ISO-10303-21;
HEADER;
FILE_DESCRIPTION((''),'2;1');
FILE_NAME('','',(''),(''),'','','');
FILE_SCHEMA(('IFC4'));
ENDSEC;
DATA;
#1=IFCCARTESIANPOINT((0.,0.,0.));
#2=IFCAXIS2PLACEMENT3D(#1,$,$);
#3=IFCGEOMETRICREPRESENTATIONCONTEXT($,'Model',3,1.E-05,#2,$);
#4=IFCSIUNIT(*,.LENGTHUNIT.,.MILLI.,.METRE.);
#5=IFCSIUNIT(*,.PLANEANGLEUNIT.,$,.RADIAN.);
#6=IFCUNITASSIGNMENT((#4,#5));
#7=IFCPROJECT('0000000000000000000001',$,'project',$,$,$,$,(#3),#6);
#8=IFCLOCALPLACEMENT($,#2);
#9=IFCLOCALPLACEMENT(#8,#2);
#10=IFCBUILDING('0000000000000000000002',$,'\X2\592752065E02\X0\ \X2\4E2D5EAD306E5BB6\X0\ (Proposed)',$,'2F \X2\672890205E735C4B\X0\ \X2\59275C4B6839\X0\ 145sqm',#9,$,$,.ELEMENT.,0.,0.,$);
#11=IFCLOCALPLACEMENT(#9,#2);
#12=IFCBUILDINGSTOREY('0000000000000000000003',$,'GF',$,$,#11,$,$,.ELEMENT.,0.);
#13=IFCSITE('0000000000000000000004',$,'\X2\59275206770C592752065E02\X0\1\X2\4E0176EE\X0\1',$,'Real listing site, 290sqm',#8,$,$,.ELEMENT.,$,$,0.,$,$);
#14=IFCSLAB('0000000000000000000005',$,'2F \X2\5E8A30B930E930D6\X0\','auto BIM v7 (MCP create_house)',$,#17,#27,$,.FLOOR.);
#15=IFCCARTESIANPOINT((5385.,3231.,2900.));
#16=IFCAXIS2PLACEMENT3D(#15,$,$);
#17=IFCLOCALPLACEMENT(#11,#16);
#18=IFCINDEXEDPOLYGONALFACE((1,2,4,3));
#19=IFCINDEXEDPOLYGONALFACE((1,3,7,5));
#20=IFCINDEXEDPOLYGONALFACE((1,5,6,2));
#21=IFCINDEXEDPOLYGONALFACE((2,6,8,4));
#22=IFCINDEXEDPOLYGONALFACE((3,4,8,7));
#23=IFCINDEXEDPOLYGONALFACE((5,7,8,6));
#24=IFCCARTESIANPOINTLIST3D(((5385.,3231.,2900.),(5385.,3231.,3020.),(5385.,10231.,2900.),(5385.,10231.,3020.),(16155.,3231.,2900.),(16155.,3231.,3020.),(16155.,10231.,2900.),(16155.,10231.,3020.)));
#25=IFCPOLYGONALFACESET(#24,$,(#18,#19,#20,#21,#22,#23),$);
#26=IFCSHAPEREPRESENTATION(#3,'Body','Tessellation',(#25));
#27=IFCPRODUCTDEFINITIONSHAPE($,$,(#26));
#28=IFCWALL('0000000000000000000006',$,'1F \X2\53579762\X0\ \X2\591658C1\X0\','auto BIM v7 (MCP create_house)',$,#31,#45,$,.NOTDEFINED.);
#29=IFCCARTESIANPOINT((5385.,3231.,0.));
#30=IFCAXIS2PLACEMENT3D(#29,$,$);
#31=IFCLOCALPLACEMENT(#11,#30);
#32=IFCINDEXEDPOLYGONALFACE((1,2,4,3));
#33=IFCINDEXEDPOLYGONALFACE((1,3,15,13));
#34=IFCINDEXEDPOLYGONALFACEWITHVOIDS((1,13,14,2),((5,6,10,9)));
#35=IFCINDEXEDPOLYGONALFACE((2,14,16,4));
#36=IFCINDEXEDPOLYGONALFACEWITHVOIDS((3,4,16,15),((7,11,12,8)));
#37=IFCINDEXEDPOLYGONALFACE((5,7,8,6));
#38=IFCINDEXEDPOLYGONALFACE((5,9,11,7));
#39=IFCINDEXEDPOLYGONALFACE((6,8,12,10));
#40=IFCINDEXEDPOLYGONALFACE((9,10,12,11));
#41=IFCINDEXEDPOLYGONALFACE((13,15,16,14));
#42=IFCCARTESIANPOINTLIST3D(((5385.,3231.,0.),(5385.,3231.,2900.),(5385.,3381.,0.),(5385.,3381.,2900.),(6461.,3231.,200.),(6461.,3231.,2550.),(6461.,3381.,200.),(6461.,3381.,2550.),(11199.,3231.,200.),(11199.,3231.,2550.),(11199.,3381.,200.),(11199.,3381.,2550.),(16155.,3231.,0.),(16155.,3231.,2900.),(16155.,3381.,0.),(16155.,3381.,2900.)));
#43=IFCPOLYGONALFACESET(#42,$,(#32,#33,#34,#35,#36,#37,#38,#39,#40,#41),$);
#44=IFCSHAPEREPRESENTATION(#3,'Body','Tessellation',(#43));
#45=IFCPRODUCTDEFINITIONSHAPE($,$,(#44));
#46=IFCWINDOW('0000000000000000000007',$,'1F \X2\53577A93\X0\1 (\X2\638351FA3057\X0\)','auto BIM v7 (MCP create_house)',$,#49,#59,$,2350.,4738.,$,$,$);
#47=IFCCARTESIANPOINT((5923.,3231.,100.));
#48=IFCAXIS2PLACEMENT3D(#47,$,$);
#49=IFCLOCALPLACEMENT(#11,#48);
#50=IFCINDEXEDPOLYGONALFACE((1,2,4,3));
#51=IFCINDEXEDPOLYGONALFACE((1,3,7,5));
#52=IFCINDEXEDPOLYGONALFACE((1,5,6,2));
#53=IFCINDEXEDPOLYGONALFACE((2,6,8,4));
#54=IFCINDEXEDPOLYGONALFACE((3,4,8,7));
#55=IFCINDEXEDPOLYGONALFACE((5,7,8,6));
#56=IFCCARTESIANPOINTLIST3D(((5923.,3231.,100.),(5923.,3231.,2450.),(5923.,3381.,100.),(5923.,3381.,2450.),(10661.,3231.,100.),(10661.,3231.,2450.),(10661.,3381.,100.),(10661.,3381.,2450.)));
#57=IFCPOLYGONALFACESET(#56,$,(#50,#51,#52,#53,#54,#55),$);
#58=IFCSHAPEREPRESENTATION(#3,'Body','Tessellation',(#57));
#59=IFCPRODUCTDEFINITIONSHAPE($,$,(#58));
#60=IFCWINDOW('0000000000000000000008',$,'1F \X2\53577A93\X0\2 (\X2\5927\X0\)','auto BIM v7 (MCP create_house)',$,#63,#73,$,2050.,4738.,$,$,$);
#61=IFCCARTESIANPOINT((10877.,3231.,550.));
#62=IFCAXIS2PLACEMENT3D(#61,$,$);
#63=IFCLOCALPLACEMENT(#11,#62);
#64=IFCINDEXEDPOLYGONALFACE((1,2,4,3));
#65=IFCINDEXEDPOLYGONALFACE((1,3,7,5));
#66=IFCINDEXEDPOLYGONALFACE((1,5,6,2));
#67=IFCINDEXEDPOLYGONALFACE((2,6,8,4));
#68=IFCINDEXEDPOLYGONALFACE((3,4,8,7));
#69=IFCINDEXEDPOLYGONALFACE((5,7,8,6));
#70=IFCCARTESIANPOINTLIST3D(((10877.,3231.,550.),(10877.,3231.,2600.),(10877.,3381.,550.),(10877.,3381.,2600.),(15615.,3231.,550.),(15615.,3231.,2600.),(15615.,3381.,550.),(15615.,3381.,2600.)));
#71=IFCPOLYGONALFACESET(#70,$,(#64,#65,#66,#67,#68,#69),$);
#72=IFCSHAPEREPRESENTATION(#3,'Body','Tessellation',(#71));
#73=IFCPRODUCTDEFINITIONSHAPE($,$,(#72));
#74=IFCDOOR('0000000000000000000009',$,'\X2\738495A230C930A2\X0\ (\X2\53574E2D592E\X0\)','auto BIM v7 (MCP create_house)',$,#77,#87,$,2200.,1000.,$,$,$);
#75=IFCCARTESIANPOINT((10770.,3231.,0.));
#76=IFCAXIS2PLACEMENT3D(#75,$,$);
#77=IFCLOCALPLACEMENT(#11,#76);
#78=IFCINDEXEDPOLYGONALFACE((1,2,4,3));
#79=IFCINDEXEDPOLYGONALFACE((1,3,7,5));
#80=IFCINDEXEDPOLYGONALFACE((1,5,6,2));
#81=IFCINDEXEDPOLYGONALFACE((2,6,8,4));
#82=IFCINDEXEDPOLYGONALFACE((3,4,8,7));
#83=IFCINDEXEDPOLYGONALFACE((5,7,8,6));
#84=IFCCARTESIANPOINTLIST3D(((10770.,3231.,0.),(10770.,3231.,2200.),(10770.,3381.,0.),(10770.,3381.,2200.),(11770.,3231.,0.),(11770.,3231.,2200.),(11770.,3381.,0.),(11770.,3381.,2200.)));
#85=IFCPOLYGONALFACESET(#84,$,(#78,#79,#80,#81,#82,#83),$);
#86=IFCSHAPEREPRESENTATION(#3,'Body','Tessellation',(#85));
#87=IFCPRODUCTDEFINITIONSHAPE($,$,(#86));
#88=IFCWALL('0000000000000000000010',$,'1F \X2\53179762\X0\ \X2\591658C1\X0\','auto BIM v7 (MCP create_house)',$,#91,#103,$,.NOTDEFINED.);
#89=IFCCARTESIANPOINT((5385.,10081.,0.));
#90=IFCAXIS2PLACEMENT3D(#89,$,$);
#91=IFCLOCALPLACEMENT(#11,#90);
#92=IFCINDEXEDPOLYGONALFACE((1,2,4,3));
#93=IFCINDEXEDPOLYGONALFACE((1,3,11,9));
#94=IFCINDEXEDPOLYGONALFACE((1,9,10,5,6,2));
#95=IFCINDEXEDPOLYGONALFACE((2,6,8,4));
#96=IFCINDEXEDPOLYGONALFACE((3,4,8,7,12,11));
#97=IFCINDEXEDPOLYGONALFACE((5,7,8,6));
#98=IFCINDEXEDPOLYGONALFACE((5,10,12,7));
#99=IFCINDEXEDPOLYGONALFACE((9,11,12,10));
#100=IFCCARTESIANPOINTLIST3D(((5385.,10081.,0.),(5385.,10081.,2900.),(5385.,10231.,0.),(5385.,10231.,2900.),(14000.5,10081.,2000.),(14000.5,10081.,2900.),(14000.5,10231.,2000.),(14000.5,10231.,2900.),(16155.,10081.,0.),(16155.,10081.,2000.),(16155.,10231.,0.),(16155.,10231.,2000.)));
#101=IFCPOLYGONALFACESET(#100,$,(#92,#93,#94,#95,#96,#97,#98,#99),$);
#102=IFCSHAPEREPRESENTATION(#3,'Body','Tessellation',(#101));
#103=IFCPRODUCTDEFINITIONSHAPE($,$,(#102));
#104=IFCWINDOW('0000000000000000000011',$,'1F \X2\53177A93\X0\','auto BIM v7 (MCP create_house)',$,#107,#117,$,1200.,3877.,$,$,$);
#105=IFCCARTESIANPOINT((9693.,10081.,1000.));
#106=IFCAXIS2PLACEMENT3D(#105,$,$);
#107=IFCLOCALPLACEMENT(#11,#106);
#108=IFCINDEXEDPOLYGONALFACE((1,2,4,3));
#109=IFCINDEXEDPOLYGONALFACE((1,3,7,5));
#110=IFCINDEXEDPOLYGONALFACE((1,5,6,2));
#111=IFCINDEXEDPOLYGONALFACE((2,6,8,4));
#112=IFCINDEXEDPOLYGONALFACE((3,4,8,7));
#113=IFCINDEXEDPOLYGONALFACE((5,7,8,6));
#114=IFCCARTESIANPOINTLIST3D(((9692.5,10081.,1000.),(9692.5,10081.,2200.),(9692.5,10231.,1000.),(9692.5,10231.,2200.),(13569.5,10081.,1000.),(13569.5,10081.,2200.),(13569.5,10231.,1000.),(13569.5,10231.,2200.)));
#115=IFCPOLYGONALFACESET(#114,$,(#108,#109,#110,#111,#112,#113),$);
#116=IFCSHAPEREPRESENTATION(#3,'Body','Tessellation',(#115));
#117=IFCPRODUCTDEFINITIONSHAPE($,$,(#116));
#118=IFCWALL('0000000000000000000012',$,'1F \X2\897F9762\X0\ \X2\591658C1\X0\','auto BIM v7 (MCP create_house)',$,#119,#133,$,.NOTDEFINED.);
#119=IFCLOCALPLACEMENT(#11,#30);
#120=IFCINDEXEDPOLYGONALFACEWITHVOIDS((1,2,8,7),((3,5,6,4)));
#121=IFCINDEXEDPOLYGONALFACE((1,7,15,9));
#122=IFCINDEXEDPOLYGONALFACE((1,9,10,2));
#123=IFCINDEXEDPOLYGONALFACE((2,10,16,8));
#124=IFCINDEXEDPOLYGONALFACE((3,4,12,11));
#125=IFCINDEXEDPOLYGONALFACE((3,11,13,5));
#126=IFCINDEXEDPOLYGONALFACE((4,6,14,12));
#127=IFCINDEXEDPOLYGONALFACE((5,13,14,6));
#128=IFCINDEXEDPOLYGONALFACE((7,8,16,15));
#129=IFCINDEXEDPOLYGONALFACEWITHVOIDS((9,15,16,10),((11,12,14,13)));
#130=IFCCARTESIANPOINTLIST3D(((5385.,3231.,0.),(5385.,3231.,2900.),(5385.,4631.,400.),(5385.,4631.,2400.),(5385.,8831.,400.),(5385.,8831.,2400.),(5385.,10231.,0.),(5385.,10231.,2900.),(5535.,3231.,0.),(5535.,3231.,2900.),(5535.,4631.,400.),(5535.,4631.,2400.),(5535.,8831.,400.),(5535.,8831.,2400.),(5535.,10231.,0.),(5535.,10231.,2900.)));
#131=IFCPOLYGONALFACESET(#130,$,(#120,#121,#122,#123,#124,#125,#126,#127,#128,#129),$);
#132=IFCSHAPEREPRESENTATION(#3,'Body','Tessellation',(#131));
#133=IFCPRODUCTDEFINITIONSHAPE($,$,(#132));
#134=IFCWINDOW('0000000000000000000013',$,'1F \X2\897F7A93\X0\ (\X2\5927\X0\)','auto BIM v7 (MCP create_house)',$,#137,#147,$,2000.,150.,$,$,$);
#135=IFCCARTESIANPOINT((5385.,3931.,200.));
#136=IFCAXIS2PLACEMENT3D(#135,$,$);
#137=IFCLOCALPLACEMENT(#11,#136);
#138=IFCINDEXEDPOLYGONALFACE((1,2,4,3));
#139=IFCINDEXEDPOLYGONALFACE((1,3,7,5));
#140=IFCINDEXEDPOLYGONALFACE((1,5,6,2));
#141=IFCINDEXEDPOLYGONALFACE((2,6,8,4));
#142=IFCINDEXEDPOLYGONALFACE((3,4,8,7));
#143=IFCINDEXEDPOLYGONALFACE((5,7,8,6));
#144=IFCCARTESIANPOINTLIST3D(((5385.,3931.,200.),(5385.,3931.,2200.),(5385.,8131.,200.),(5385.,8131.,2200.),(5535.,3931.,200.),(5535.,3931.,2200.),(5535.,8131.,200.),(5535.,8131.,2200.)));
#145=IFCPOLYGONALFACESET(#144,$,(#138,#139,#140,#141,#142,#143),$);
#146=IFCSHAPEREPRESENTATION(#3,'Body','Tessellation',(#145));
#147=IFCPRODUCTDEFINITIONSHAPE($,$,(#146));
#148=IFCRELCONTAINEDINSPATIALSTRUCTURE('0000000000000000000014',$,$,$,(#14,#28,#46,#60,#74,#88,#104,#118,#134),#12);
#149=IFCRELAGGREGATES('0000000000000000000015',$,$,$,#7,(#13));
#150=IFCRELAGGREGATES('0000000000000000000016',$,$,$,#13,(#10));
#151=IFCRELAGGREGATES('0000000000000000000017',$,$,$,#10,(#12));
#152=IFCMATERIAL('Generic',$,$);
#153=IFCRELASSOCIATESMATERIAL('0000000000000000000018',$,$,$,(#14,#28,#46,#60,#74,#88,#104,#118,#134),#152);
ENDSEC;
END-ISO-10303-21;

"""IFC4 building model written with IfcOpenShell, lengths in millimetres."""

from ifc_helpers import new_model, si_unit, frame, frame_2d, origin, place, context, project, spatial, rectangle, extrude, material, element, fill, save


model = new_model("IFC4")

# Units and contexts
model_context = context("Model", 3, precision=1e-05, world=origin())
ifc_project = project(units=[si_unit("LENGTHUNIT", "METRE", prefix="MILLI"), si_unit("PLANEANGLEUNIT", "RADIAN")], contexts=[model_context])

# Site, building, storey
site_placement = place(None, origin())
site = spatial("IfcSite", under=ifc_project, at=site_placement, Name="大分県大分市1丁目1", ObjectType="Real listing site, 290sqm", CompositionType="ELEMENT", RefElevation=0.0)
building_placement = place(site_placement, origin())
building = spatial("IfcBuilding", under=site, at=building_placement, Name="大分市 中庭の家 (Proposed)", ObjectType="2F 木造平屋 大屋根 145sqm", CompositionType="ELEMENT", ElevationOfRefHeight=0.0, ElevationOfTerrain=0.0)
storey_placement = place(building_placement, origin())
storey = spatial("IfcBuildingStorey", under=building, at=storey_placement, Name="GF", CompositionType="ELEMENT", Elevation=0.0)

# Slab
ifc_material = material(Name="Generic")
slab_1_placement = place(storey_placement, frame((5385.0, 3231.0, 2900.0)))
element("IfcSlab", 1, at=slab_1_placement, inside=storey, material=ifc_material, Name="2F 床スラブ", Description="auto BIM v7 (MCP create_house)", PredefinedType="FLOOR", context=model_context, shape_type="SweptSolid", body=[
    extrude(rectangle(XDim=10770.0, YDim=7000.0, at=frame_2d((5385.0, 3500.0))), frame((5385.0, 3231.0, 2900.0)), (0.0, 0.0, 1.0), 120.0),
])

# Wall, openings, windows, door
wall_1_placement = place(storey_placement, frame((5385.0, 3231.0, 0.0)))
wall_1 = element("IfcWall", 2, at=wall_1_placement, inside=storey, material=ifc_material, Name="1F 南面 外壁", Description="auto BIM v7 (MCP create_house)", PredefinedType="NOTDEFINED", context=model_context, shape_type="SweptSolid", body=[
    extrude(rectangle(XDim=10770.0, YDim=150.0, at=frame_2d((5385.0, 75.0))), frame((5385.0, 3231.0, 0.0)), (0.0, 0.0, 1.0), 2900.0),
])
opening_1_placement = place(storey_placement, frame((5923.0, 3231.0, 100.0)))
opening_1 = element("IfcOpeningElement", 3, at=opening_1_placement, cuts=wall_1, PredefinedType="NOTDEFINED", context=model_context, shape_type="SweptSolid", body=[
    extrude(rectangle(XDim=4738.0, YDim=150.0, at=frame_2d((2369.0, 75.0))), frame((5923.0, 3231.0, 100.0)), (0.0, 0.0, 1.0), 2350.0),
])
opening_2_placement = place(storey_placement, frame((10877.0, 3231.0, 550.0)))
opening_2 = element("IfcOpeningElement", 4, at=opening_2_placement, cuts=wall_1, PredefinedType="NOTDEFINED", context=model_context, shape_type="SweptSolid", body=[
    extrude(rectangle(XDim=4738.0, YDim=150.0, at=frame_2d((2369.0, 75.0))), frame((10877.0, 3231.0, 550.0)), (0.0, 0.0, 1.0), 2050.0),
])
opening_3_placement = place(storey_placement, frame((10770.0, 3231.0, 0.0)))
opening_3 = element("IfcOpeningElement", 5, at=opening_3_placement, cuts=wall_1, PredefinedType="NOTDEFINED", context=model_context, shape_type="SweptSolid", body=[
    extrude(rectangle(XDim=1000.0, YDim=150.0, at=frame_2d((500.0, 75.0))), frame((10770.0, 3231.0, 0.0)), (0.0, 0.0, 1.0), 2200.0),
])
window_1_placement = place(storey_placement, frame((5923.0, 3231.0, 100.0)))
window_1 = element("IfcWindow", 6, at=window_1_placement, inside=storey, material=ifc_material, Name="1F 南窓1 (掃出し)", Description="auto BIM v7 (MCP create_house)", OverallHeight=2350.0, OverallWidth=4738.0, context=model_context, shape_type="SweptSolid", body=[
    extrude(rectangle(XDim=4738.0, YDim=150.0, at=frame_2d((2369.0, 75.0))), frame((5923.0, 3231.0, 100.0)), (0.0, 0.0, 1.0), 2350.0),
])
fill(opening_1, window_1)
window_2_placement = place(storey_placement, frame((10877.0, 3231.0, 550.0)))
window_2 = element("IfcWindow", 7, at=window_2_placement, inside=storey, material=ifc_material, Name="1F 南窓2 (大)", Description="auto BIM v7 (MCP create_house)", OverallHeight=2050.0, OverallWidth=4738.0, context=model_context, shape_type="SweptSolid", body=[
    extrude(rectangle(XDim=4738.0, YDim=150.0, at=frame_2d((2369.0, 75.0))), frame((10877.0, 3231.0, 550.0)), (0.0, 0.0, 1.0), 2050.0),
])
fill(opening_2, window_2)
door_placement = place(storey_placement, frame((10770.0, 3231.0, 0.0)))
door = element("IfcDoor", 8, at=door_placement, inside=storey, material=ifc_material, Name="玄関ドア (南中央)", Description="auto BIM v7 (MCP create_house)", OverallHeight=2200.0, OverallWidth=1000.0, context=model_context, shape_type="SweptSolid", body=[
    extrude(rectangle(XDim=1000.0, YDim=150.0, at=frame_2d((500.0, 75.0))), frame((10770.0, 3231.0, 0.0)), (0.0, 0.0, 1.0), 2200.0),
])
fill(opening_3, door)

# Walls, openings, windows
wall_2_placement = place(storey_placement, frame((5385.0, 10081.0, 0.0)))
wall_2 = element("IfcWall", 9, at=wall_2_placement, inside=storey, material=ifc_material, Name="1F 北面 外壁", Description="auto BIM v7 (MCP create_house)", PredefinedType="NOTDEFINED", context=model_context, shape_type="SweptSolid", body=[
    extrude(rectangle(XDim=10770.0, YDim=150.0, at=frame_2d((5385.0, 75.0))), frame((5385.0, 10081.0, 0.0)), (0.0, 0.0, 1.0), 2900.0),
])
opening_4_placement = place(storey_placement, frame((9693.0, 10081.0, 1000.0)))
opening_4 = element("IfcOpeningElement", 10, at=opening_4_placement, cuts=wall_2, PredefinedType="NOTDEFINED", context=model_context, shape_type="SweptSolid", body=[
    extrude(rectangle(XDim=3877.0, YDim=150.0, at=frame_2d((1938.0, 75.0))), frame((9693.0, 10081.0, 1000.0)), (0.0, 0.0, 1.0), 1200.0),
])
window_3_placement = place(storey_placement, frame((9693.0, 10081.0, 1000.0)))
window_3 = element("IfcWindow", 11, at=window_3_placement, inside=storey, material=ifc_material, Name="1F 北窓", Description="auto BIM v7 (MCP create_house)", OverallHeight=1200.0, OverallWidth=3877.0, context=model_context, shape_type="SweptSolid", body=[
    extrude(rectangle(XDim=3877.0, YDim=150.0, at=frame_2d((1938.0, 75.0))), frame((9693.0, 10081.0, 1000.0)), (0.0, 0.0, 1.0), 1200.0),
])
fill(opening_4, window_3)
wall_3_placement = place(storey_placement, frame((5385.0, 3231.0, 0.0)))
wall_3 = element("IfcWall", 12, at=wall_3_placement, inside=storey, material=ifc_material, Name="1F 西面 外壁", Description="auto BIM v7 (MCP create_house)", PredefinedType="NOTDEFINED", context=model_context, shape_type="SweptSolid", body=[
    extrude(rectangle(XDim=150.0, YDim=7000.0, at=frame_2d((75.0, 3500.0))), frame((5385.0, 3231.0, 0.0)), (0.0, 0.0, 1.0), 2900.0),
])
opening_5_placement = place(storey_placement, frame((5385.0, 3931.0, 200.0)))
opening_5 = element("IfcOpeningElement", 13, at=opening_5_placement, cuts=wall_3, PredefinedType="NOTDEFINED", context=model_context, shape_type="SweptSolid", body=[
    extrude(rectangle(XDim=150.0, YDim=4200.0, at=frame_2d((75.0, 2100.0))), frame((5385.0, 3931.0, 200.0)), (0.0, 0.0, 1.0), 2000.0),
])
window_4_placement = place(storey_placement, frame((5385.0, 3931.0, 200.0)))
window_4 = element("IfcWindow", 14, at=window_4_placement, inside=storey, material=ifc_material, Name="1F 西窓 (大)", Description="auto BIM v7 (MCP create_house)", OverallHeight=2000.0, OverallWidth=150.0, context=model_context, shape_type="SweptSolid", body=[
    extrude(rectangle(XDim=150.0, YDim=4200.0, at=frame_2d((75.0, 2100.0))), frame((5385.0, 3931.0, 200.0)), (0.0, 0.0, 1.0), 2000.0),
])
fill(opening_5, window_4)

save(model, "model.ifc")
